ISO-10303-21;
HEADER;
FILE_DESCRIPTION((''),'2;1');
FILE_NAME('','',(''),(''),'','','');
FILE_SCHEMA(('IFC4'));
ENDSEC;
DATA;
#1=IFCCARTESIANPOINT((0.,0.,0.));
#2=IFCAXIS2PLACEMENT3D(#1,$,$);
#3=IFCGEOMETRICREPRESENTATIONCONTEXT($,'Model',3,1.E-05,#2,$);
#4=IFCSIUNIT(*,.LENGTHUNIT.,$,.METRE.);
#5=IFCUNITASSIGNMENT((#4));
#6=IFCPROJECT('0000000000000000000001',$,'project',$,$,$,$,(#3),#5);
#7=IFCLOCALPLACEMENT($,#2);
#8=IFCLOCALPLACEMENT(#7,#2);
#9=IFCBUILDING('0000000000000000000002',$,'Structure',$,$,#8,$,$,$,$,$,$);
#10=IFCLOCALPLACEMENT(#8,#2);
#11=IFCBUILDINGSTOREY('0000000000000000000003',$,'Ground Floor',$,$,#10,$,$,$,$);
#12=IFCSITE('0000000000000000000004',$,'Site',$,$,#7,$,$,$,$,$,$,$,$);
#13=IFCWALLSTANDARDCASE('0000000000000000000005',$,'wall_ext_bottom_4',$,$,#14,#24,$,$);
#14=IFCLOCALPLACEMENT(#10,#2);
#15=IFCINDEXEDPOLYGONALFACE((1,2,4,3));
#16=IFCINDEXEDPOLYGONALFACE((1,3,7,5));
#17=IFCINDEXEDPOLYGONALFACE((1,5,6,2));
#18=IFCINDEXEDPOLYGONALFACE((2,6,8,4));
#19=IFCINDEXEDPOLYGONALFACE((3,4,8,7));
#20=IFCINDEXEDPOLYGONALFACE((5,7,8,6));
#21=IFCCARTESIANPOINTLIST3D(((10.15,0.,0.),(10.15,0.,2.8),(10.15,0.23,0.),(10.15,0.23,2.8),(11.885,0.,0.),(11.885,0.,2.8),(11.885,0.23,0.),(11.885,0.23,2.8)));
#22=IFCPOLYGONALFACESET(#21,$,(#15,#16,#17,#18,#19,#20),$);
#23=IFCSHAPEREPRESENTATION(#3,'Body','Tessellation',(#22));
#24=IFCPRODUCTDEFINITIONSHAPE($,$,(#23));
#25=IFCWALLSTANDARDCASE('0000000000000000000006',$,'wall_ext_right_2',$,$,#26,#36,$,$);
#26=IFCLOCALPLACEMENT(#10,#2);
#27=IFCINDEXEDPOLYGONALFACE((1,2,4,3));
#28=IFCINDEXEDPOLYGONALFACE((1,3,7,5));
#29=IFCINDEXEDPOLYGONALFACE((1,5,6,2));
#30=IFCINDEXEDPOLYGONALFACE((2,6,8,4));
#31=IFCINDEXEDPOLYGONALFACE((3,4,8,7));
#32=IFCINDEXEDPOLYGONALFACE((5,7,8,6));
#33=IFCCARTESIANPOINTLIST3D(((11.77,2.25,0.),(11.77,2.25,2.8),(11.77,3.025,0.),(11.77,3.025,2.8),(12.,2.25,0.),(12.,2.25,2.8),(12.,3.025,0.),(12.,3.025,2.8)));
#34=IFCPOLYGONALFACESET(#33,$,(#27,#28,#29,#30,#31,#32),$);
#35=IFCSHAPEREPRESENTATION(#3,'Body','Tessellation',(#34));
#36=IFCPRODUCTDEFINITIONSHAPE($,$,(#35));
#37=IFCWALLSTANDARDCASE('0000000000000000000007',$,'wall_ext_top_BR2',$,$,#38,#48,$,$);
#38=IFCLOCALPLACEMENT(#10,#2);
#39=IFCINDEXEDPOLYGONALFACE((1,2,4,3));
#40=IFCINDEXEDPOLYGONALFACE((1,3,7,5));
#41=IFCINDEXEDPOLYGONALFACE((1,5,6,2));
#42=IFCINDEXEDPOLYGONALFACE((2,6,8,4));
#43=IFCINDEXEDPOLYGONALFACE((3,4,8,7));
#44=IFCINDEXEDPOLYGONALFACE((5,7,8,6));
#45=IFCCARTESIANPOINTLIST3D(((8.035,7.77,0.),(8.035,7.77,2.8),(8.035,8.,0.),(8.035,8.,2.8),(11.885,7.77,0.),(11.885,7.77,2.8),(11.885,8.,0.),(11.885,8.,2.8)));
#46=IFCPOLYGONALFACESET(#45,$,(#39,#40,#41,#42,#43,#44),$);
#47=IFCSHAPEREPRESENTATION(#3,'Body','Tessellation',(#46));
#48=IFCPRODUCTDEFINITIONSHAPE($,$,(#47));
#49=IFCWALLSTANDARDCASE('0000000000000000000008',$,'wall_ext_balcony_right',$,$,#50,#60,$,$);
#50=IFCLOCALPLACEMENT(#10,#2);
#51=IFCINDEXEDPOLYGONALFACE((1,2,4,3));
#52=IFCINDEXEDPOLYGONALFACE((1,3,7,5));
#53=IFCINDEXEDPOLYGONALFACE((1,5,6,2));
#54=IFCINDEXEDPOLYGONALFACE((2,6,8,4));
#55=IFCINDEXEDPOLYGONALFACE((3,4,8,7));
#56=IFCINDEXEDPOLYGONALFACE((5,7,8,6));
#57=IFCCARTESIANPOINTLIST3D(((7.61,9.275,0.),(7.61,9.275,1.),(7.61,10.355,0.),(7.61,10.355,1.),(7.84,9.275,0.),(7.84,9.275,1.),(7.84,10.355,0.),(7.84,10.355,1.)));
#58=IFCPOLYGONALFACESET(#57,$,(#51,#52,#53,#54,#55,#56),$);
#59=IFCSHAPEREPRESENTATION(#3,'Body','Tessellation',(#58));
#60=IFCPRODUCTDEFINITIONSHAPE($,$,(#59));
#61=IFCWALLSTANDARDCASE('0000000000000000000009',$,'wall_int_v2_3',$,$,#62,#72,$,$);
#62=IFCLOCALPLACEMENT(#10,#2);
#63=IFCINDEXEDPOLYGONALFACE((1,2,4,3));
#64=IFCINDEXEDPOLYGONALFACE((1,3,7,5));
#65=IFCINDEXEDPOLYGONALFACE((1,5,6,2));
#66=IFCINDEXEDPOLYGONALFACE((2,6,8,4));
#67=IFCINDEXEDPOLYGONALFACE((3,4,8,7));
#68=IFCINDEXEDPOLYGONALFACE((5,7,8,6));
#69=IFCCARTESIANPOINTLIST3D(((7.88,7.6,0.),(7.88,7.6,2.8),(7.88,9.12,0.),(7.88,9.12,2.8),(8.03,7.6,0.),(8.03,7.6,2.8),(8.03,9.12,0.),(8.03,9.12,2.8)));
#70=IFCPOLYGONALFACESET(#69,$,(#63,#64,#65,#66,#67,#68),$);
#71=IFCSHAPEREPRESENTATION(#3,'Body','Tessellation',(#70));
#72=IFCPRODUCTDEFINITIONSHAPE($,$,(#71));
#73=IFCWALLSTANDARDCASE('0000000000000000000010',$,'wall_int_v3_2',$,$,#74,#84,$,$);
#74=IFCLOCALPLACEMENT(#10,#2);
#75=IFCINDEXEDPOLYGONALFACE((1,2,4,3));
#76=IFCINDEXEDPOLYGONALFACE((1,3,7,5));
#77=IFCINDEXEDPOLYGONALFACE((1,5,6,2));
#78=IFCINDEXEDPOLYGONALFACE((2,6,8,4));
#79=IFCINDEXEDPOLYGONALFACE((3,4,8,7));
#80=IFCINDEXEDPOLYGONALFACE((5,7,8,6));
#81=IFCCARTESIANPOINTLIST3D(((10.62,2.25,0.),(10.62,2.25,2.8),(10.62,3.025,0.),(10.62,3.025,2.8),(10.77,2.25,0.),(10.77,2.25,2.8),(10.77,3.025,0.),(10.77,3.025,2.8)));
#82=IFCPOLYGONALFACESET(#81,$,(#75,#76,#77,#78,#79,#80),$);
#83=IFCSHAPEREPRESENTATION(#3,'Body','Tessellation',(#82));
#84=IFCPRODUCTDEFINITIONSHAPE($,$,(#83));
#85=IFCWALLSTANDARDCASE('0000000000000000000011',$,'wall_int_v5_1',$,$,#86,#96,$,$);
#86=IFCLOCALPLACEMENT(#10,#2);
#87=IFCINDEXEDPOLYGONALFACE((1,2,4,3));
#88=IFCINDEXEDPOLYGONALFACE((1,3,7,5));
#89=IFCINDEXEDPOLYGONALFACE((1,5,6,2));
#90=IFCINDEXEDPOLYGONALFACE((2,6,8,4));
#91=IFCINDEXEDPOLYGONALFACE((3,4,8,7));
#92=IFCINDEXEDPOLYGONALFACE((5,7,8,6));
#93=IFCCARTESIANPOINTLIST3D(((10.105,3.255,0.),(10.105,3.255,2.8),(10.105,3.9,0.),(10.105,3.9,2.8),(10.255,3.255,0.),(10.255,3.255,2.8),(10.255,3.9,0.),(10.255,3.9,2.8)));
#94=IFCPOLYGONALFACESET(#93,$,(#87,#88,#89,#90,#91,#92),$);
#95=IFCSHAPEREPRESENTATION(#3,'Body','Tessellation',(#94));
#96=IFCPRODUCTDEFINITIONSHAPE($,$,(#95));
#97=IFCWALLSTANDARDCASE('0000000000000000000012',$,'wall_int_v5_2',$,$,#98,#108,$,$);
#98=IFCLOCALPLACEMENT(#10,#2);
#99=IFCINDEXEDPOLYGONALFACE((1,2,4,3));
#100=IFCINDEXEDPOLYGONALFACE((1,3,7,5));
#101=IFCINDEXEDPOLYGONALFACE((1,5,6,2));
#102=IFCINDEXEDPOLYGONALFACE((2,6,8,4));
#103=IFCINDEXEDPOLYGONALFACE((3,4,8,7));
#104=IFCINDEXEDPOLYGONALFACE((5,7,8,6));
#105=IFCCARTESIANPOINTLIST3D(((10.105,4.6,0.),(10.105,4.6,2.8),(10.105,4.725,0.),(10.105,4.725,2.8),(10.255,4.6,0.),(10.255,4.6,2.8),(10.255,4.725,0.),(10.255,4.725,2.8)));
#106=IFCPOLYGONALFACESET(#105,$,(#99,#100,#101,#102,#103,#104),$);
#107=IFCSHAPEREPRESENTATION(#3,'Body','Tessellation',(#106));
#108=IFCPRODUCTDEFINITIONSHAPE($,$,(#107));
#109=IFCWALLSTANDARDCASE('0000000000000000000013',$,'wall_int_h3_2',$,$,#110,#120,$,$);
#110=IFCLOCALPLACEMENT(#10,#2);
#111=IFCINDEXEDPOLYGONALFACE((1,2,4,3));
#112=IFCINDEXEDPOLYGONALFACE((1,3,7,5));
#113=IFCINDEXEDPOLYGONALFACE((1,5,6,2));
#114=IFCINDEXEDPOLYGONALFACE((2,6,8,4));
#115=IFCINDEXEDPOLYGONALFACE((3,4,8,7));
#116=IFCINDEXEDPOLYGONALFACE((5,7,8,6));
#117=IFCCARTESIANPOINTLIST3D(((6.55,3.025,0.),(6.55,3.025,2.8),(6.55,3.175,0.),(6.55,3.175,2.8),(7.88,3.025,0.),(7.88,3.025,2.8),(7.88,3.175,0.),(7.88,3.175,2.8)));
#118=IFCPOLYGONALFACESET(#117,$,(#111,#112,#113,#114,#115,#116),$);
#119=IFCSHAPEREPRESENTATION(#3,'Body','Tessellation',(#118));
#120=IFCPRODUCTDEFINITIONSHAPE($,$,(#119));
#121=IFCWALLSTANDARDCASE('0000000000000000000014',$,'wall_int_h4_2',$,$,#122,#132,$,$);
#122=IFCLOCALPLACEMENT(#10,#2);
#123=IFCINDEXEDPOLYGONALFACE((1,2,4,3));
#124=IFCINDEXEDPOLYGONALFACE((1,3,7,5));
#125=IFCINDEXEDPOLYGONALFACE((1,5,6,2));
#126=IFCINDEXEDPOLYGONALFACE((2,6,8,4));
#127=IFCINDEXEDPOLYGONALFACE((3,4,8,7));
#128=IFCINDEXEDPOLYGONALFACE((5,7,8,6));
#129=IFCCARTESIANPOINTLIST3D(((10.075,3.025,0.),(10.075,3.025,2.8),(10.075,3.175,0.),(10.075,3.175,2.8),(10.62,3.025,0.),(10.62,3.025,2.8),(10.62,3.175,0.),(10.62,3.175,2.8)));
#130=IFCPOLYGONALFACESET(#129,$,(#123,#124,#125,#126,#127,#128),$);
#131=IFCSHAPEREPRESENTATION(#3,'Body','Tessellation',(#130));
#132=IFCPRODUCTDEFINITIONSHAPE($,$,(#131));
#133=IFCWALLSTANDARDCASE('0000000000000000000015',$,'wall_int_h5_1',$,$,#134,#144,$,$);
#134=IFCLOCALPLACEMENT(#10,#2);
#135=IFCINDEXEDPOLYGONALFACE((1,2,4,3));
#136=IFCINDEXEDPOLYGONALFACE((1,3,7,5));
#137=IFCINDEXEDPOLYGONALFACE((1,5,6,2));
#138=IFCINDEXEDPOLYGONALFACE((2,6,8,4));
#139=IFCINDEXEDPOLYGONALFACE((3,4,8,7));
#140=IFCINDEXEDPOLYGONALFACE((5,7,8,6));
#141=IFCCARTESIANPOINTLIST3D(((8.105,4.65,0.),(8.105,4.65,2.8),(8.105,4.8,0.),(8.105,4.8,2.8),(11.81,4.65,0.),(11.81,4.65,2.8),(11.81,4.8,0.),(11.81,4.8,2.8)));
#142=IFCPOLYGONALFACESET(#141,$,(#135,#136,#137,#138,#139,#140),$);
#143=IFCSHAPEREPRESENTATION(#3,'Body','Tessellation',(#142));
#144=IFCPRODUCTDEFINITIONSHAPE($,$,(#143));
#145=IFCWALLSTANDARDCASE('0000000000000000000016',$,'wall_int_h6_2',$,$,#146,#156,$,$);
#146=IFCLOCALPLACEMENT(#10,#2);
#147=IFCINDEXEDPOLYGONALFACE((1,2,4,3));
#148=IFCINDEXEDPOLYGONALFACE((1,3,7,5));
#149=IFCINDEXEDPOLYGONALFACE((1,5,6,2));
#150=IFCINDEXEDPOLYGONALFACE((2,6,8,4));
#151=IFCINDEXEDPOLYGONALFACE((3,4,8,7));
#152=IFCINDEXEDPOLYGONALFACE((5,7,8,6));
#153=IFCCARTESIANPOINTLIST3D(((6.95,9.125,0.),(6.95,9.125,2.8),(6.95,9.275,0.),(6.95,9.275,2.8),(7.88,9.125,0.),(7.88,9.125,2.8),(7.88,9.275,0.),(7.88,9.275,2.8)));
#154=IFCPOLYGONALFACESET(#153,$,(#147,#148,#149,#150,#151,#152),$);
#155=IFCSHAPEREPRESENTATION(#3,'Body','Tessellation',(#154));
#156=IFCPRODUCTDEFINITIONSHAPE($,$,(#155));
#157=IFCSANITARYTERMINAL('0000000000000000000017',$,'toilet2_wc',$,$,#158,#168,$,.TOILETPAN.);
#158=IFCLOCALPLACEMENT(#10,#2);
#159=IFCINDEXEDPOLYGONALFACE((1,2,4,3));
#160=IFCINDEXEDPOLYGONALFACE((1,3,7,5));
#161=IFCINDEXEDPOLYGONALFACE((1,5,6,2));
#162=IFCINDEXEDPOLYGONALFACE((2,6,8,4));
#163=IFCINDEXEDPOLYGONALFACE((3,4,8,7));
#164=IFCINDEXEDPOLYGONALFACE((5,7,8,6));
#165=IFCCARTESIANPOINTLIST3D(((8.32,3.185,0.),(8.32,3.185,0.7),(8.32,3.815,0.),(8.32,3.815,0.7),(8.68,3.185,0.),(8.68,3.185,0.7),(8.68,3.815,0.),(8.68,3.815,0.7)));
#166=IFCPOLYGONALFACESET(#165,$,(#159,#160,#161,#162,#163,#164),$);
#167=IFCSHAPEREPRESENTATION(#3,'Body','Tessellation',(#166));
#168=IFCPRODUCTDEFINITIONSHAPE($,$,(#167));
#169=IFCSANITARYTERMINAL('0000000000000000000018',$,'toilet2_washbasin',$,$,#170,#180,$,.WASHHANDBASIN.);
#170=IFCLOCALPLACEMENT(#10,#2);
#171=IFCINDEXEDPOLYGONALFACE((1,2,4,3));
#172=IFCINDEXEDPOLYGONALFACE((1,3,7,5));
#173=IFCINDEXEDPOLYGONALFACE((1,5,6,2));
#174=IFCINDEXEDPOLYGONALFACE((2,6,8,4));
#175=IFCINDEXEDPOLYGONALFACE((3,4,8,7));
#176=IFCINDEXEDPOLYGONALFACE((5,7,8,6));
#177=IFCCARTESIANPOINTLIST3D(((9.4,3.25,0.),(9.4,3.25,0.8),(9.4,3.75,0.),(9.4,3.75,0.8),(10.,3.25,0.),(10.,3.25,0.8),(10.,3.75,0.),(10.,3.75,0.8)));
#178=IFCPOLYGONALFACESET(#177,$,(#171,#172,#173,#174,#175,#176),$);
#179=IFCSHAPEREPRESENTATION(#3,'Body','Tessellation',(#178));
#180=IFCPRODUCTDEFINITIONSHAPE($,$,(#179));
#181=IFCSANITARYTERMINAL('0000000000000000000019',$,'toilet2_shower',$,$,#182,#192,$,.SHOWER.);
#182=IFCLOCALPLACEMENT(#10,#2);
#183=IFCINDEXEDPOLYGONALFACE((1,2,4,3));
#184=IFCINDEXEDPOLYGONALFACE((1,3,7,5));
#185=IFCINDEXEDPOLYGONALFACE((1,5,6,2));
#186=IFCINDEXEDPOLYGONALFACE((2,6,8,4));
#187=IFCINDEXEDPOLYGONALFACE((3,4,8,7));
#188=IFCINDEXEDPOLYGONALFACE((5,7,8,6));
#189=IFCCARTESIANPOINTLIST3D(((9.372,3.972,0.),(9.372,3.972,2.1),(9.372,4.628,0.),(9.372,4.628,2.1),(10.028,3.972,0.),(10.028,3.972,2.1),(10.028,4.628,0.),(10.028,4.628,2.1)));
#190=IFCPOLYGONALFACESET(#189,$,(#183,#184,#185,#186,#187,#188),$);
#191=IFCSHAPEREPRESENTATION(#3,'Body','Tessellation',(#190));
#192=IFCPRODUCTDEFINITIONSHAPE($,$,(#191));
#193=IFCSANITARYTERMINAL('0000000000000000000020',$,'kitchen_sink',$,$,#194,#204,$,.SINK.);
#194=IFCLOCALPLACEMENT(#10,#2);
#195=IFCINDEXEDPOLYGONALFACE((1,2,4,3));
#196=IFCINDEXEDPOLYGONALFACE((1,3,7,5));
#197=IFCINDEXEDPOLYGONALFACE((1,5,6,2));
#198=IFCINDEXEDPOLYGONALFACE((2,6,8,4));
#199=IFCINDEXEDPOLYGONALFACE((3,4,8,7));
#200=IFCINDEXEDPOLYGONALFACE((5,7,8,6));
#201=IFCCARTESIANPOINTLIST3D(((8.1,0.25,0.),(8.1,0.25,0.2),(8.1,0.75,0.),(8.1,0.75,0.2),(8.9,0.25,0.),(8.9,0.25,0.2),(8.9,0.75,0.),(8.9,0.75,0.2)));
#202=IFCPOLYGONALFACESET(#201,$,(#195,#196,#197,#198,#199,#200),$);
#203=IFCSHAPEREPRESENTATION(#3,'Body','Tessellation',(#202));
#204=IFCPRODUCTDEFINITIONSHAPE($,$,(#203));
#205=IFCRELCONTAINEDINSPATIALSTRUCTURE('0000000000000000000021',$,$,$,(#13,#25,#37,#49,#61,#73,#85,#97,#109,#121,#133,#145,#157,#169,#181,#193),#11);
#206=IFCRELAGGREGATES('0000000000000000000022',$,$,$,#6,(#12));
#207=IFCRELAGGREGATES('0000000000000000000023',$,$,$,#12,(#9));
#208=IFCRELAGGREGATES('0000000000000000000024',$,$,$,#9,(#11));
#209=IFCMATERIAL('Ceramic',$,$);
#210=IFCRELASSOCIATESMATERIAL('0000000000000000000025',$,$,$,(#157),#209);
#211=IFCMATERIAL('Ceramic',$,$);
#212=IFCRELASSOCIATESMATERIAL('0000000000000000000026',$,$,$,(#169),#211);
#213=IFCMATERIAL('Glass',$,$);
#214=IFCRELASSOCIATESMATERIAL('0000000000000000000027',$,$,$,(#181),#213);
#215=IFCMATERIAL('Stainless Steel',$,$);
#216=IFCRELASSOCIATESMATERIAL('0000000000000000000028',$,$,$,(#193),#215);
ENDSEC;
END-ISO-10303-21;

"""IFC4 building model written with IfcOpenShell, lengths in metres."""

from ifc_helpers import new_model, si_unit, frame, origin, place, context, project, spatial, polyline, outline, extrude, material, element, save


model = new_model("IFC4")

# Units and contexts
model_context = context("Model", 3, precision=1e-05, world=origin())
ifc_project = project(units=[si_unit("LENGTHUNIT", "METRE")], contexts=[model_context])

# Site, building, storey
site_placement = place(None, origin())
site = spatial("IfcSite", under=ifc_project, at=site_placement, Name="Site")
building_placement = place(site_placement, origin())
building = spatial("IfcBuilding", under=site, at=building_placement, Name="Structure")
storey_placement = place(building_placement, origin())
storey = spatial("IfcBuildingStorey", under=building, at=storey_placement, Name="Ground Floor")

# Walls
wall_1_placement = place(storey_placement, frame((10.15, 0.115, 0.0), x_axis=(1.0, 0.0, 0.0)))
element("IfcWallStandardCase", 1, at=wall_1_placement, inside=storey, Name="wall_ext_bottom_4", context=model_context, shape_type="SweptSolid", body=[
    extrude(outline(polyline([(0.0, -0.115), (1.735, -0.115), (1.735, 0.115), (0.0, 0.115), (0.0, -0.115)])), origin(), (0.0, 0.0, 1.0), 2.8),
])
wall_2_placement = place(storey_placement, frame((11.885, 2.25, 0.0), x_axis=(0.0, 1.0, 0.0)))
element("IfcWallStandardCase", 2, at=wall_2_placement, inside=storey, Name="wall_ext_right_2", context=model_context, shape_type="SweptSolid", body=[
    extrude(outline(polyline([(0.0, -0.115), (0.775, -0.115), (0.775, 0.115), (0.0, 0.115), (0.0, -0.115)])), origin(), (0.0, 0.0, 1.0), 2.8),
])
wall_3_placement = place(storey_placement, frame((8.035, 7.885, 0.0), x_axis=(1.0, 0.0, 0.0)))
element("IfcWallStandardCase", 3, at=wall_3_placement, inside=storey, Name="wall_ext_top_BR2", context=model_context, shape_type="SweptSolid", body=[
    extrude(outline(polyline([(0.0, -0.115), (3.85, -0.115), (3.85, 0.115), (0.0, 0.115), (0.0, -0.115)])), origin(), (0.0, 0.0, 1.0), 2.8),
])
wall_4_placement = place(storey_placement, frame((7.725, 9.275, 0.0), x_axis=(0.0, 1.0, 0.0)))
element("IfcWallStandardCase", 4, at=wall_4_placement, inside=storey, Name="wall_ext_balcony_right", context=model_context, shape_type="SweptSolid", body=[
    extrude(outline(polyline([(0.0, -0.115), (1.08, -0.115), (1.08, 0.115), (0.0, 0.115), (0.0, -0.115)])), origin(), (0.0, 0.0, 1.0), 1.0),
])
wall_5_placement = place(storey_placement, frame((7.955, 7.6, 0.0), x_axis=(0.0, 1.0, 0.0)))
element("IfcWallStandardCase", 5, at=wall_5_placement, inside=storey, Name="wall_int_v2_3", context=model_context, shape_type="SweptSolid", body=[
    extrude(outline(polyline([(0.0, -0.075), (1.52, -0.075), (1.52, 0.075), (0.0, 0.075), (0.0, -0.075)])), origin(), (0.0, 0.0, 1.0), 2.8),
])
wall_6_placement = place(storey_placement, frame((10.695, 2.25, 0.0), x_axis=(0.0, 1.0, 0.0)))
element("IfcWallStandardCase", 6, at=wall_6_placement, inside=storey, Name="wall_int_v3_2", context=model_context, shape_type="SweptSolid", body=[
    extrude(outline(polyline([(0.0, -0.075), (0.775, -0.075), (0.775, 0.075), (0.0, 0.075), (0.0, -0.075)])), origin(), (0.0, 0.0, 1.0), 2.8),
])
wall_7_placement = place(storey_placement, frame((10.18, 3.255, 0.0), x_axis=(0.0, 1.0, 0.0)))
element("IfcWallStandardCase", 7, at=wall_7_placement, inside=storey, Name="wall_int_v5_1", context=model_context, shape_type="SweptSolid", body=[
    extrude(outline(polyline([(0.0, -0.075), (0.645, -0.075), (0.645, 0.075), (0.0, 0.075), (0.0, -0.075)])), origin(), (0.0, 0.0, 1.0), 2.8),
])
wall_8_placement = place(storey_placement, frame((10.18, 4.6, 0.0), x_axis=(0.0, 1.0, 0.0)))
element("IfcWallStandardCase", 8, at=wall_8_placement, inside=storey, Name="wall_int_v5_2", context=model_context, shape_type="SweptSolid", body=[
    extrude(outline(polyline([(0.0, -0.075), (0.125, -0.075), (0.125, 0.075), (0.0, 0.075), (0.0, -0.075)])), origin(), (0.0, 0.0, 1.0), 2.8),
])
wall_9_placement = place(storey_placement, frame((6.55, 3.1, 0.0), x_axis=(1.0, 0.0, 0.0)))
element("IfcWallStandardCase", 9, at=wall_9_placement, inside=storey, Name="wall_int_h3_2", context=model_context, shape_type="SweptSolid", body=[
    extrude(outline(polyline([(0.0, -0.075), (1.33, -0.075), (1.33, 0.075), (0.0, 0.075), (0.0, -0.075)])), origin(), (0.0, 0.0, 1.0), 2.8),
])
wall_10_placement = place(storey_placement, frame((10.075, 3.1, 0.0), x_axis=(1.0, 0.0, 0.0)))
element("IfcWallStandardCase", 10, at=wall_10_placement, inside=storey, Name="wall_int_h4_2", context=model_context, shape_type="SweptSolid", body=[
    extrude(outline(polyline([(0.0, -0.075), (0.545, -0.075), (0.545, 0.075), (0.0, 0.075), (0.0, -0.075)])), origin(), (0.0, 0.0, 1.0), 2.8),
])
wall_11_placement = place(storey_placement, frame((8.105, 4.725, 0.0), x_axis=(1.0, 0.0, 0.0)))
element("IfcWallStandardCase", 11, at=wall_11_placement, inside=storey, Name="wall_int_h5_1", context=model_context, shape_type="SweptSolid", body=[
    extrude(outline(polyline([(0.0, -0.075), (3.705, -0.075), (3.705, 0.075), (0.0, 0.075), (0.0, -0.075)])), origin(), (0.0, 0.0, 1.0), 2.8),
])
wall_12_placement = place(storey_placement, frame((6.95, 9.2, 0.0), x_axis=(1.0, 0.0, 0.0)))
element("IfcWallStandardCase", 12, at=wall_12_placement, inside=storey, Name="wall_int_h6_2", context=model_context, shape_type="SweptSolid", body=[
    extrude(outline(polyline([(0.0, -0.075), (0.93, -0.075), (0.93, 0.075), (0.0, 0.075), (0.0, -0.075)])), origin(), (0.0, 0.0, 1.0), 2.8),
])

# Sanitary terminals
ifc_material_1 = material(Name="Ceramic")
sanitary_terminal_1_placement = place(storey_placement, frame((8.5, 3.5, 0.0)))
element("IfcSanitaryTerminal", 13, at=sanitary_terminal_1_placement, inside=storey, material=ifc_material_1, Name="toilet2_wc", PredefinedType="TOILETPAN", context=model_context, shape_type="SweptSolid", body=[
    extrude(outline(polyline([(-0.18, -0.315), (0.18, -0.315), (0.18, 0.315), (-0.18, 0.315), (-0.18, -0.315)])), origin(), (0.0, 0.0, 1.0), 0.7),
])
ifc_material_2 = material(Name="Ceramic")
sanitary_terminal_2_placement = place(storey_placement, frame((9.7, 3.5, 0.0)))
element("IfcSanitaryTerminal", 14, at=sanitary_terminal_2_placement, inside=storey, material=ifc_material_2, Name="toilet2_washbasin", PredefinedType="WASHHANDBASIN", context=model_context, shape_type="SweptSolid", body=[
    extrude(outline(polyline([(-0.3, -0.25), (0.3, -0.25), (0.3, 0.25), (-0.3, 0.25), (-0.3, -0.25)])), origin(), (0.0, 0.0, 1.0), 0.8),
])
ifc_material_3 = material(Name="Glass")
sanitary_terminal_3_placement = place(storey_placement, frame((9.7, 4.3, 0.0)))
element("IfcSanitaryTerminal", 15, at=sanitary_terminal_3_placement, inside=storey, material=ifc_material_3, Name="toilet2_shower", PredefinedType="SHOWER", context=model_context, shape_type="SweptSolid", body=[
    extrude(outline(polyline([(-0.3281, -0.3281), (0.3281, -0.3281), (0.3281, 0.3281), (-0.3281, 0.3281), (-0.3281, -0.3281)])), origin(), (0.0, 0.0, 1.0), 2.1),
])
ifc_material_4 = material(Name="Stainless Steel")
sanitary_terminal_4_placement = place(storey_placement, frame((8.5, 0.5, 0.0)))
element("IfcSanitaryTerminal", 16, at=sanitary_terminal_4_placement, inside=storey, material=ifc_material_4, Name="kitchen_sink", PredefinedType="SINK", context=model_context, shape_type="SweptSolid", body=[
    extrude(outline(polyline([(-0.4, -0.25), (0.4, -0.25), (0.4, 0.25), (-0.4, 0.25), (-0.4, -0.25)])), origin(), (0.0, 0.0, 1.0), 0.2),
])

save(model, "model.ifc")
